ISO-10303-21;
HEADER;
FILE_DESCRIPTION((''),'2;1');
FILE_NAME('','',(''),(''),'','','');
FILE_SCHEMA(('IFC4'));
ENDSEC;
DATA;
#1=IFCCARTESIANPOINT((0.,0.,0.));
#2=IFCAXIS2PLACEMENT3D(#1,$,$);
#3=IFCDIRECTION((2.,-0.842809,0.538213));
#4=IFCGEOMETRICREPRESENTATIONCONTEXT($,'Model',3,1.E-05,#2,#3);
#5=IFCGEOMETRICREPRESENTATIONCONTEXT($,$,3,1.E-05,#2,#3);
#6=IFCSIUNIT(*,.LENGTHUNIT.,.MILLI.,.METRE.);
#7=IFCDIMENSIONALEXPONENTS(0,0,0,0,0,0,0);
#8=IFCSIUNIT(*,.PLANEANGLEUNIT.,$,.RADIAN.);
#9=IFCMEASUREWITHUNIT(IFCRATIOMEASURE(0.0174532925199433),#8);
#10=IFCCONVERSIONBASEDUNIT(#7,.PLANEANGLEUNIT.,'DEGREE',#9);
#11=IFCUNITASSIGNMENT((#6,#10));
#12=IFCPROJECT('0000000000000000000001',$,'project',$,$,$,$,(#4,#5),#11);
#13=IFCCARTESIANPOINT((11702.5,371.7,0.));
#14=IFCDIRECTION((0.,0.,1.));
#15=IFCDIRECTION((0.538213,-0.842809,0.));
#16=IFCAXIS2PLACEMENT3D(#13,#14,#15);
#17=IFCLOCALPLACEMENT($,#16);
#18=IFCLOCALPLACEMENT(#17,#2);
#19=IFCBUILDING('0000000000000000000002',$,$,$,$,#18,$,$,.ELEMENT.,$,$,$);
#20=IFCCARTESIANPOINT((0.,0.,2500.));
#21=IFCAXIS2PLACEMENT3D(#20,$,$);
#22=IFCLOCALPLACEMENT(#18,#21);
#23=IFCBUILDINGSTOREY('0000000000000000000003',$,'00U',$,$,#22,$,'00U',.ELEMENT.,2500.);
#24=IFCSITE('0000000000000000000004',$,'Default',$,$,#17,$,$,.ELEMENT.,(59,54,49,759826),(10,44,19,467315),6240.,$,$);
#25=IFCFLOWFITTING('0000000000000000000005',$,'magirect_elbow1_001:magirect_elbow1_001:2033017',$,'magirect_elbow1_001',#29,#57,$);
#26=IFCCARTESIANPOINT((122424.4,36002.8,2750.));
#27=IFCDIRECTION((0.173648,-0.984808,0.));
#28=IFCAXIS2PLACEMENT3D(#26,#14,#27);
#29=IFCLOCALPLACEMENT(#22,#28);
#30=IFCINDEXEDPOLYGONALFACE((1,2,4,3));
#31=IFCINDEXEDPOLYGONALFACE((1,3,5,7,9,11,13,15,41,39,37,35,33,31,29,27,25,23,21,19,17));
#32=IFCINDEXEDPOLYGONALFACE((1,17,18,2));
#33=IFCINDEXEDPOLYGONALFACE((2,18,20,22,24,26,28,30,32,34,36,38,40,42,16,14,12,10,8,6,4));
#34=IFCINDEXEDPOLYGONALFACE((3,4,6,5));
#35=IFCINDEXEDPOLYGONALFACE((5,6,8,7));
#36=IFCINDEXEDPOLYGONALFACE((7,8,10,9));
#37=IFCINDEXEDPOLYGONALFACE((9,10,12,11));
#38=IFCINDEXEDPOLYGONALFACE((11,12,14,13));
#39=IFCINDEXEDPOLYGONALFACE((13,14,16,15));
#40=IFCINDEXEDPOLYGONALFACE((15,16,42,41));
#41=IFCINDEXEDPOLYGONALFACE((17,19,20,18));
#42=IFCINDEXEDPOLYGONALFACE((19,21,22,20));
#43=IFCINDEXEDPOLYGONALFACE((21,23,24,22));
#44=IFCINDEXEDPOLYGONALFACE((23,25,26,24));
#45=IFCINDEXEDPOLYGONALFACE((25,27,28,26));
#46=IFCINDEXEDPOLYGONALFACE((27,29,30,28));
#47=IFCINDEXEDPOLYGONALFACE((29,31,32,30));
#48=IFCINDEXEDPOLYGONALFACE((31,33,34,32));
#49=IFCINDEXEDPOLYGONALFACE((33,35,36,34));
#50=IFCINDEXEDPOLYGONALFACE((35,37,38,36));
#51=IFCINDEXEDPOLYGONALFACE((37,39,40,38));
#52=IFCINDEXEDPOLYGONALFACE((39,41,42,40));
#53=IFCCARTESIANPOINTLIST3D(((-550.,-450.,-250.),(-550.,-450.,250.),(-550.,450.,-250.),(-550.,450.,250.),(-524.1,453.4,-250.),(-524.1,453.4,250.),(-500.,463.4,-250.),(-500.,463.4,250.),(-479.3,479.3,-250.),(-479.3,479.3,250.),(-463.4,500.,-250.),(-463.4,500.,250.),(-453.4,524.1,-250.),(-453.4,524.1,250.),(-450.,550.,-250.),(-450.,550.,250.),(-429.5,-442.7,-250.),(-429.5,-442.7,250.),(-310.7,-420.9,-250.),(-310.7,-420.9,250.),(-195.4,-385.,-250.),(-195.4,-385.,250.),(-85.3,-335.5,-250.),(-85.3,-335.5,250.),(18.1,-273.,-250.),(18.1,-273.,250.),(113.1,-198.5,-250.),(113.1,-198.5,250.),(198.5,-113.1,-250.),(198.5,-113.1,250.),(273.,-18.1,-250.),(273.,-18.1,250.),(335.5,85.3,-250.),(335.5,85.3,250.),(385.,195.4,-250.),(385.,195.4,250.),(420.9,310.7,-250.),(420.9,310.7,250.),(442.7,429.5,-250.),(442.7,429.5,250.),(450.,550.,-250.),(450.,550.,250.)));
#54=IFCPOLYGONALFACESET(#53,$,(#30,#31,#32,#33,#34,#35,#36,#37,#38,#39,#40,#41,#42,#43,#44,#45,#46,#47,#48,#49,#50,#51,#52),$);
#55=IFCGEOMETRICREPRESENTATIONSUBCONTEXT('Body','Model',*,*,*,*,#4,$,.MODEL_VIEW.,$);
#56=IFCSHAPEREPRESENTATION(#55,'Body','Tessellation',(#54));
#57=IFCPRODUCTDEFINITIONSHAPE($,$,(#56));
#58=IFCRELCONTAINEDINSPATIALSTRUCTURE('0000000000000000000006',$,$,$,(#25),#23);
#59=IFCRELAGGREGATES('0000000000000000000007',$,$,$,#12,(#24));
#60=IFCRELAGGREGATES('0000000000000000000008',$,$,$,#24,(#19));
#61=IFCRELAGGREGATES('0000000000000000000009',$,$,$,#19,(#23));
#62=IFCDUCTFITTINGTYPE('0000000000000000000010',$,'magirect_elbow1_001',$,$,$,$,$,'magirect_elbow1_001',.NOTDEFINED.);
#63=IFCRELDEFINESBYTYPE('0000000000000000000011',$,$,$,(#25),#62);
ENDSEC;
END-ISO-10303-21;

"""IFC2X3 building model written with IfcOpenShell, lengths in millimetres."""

from ifc_helpers import new_model, entity, si_unit, converted_unit, direction, frame, frame_2d, origin, place, context, subcontext, project, spatial, polyline, circle_curve, parameter, trimmed, segment, composite_curve, outline, extrude, source, transform, mapped, type_object, type_shapes, element, save


model = new_model("IFC2X3")

# Units and contexts
model_context = context("Model", 3, precision=1e-05, world=origin(), true_north=direction((2.0, -0.842809, 0.538213)))
context_of_model = context(None, 3, precision=1e-05, world=origin(), true_north=direction((2.0, -0.842809, 0.538213)))
body_context = subcontext(model_context, "Body", "Model", "MODEL_VIEW")
ifc_project = project(units=[si_unit("LENGTHUNIT", "METRE", prefix="MILLI"), converted_unit("PLANEANGLEUNIT", "DEGREE", entity("IfcRatioMeasure", 0.0174532925199433), si_unit("PLANEANGLEUNIT", "RADIAN"), dimensions=[0, 0, 0, 0, 0, 0, 0])], contexts=[model_context, context_of_model])

# Site, building, storey
site_placement = place(None, frame((11702.5, 371.7, 0.0), z_axis=(0.0, 0.0, 1.0), x_axis=(0.538213, -0.842809, 0.0)))
site = spatial("IfcSite", under=ifc_project, at=site_placement, Name="Default", CompositionType="ELEMENT", RefLatitude=(59, 54, 49, 759826), RefLongitude=(10, 44, 19, 467315), RefElevation=6240.0)
building_placement = place(site_placement, origin())
building = spatial("IfcBuilding", under=site, at=building_placement, CompositionType="ELEMENT")
storey_placement = place(building_placement, frame((0.0, 0.0, 2500.0)))
storey = spatial("IfcBuildingStorey", under=building, at=storey_placement, Name="00U", LongName="00U", CompositionType="ELEMENT", Elevation=2500.0)

# Flow fitting
duct_fitting_type_1 = type_object("IfcDuctFittingType", Name="magirect_elbow1_001", ElementType="magirect_elbow1_001", PredefinedType="NOTDEFINED")
shared_shape_1 = source(origin(), body_context, "Body", "SweptSolid", [
    extrude(outline(composite_curve([segment(polyline([(-725.0, -275.0), (175.0, -275.0)]), True, "CONTINUOUS"), segment(trimmed(circle_curve(frame_2d((275.0, -275.0), x_axis=(0.0, 1.0)), 100.0), [parameter(0.0)], [parameter(90.0)], True, "PARAMETER"), False, "CONTINUOUS"), segment(polyline([(275.0, -175.0), (275.0, 725.0)]), True, "CONTINUOUS"), segment(trimmed(circle_curve(frame_2d((275.0, -275.0), x_axis=(0.0, 1.0)), 1000.0), [parameter(0.0)], [parameter(90.0)], True, "PARAMETER"), True, "CONTINUOUS")], self_intersect=False)), frame((-275.0, 275.0, -250.0), z_axis=(0.0, 0.0, 1.0), x_axis=(-1.0, 0.0, 0.0)), (0.0, 0.0, 1.0), 500.0),
])
type_shapes(duct_fitting_type_1, [shared_shape_1])
flow_fitting_1_placement = place(storey_placement, frame((122424.4, 36002.8, 2750.0), z_axis=(0.0, 0.0, 1.0), x_axis=(0.173648, -0.984808, 0.0)))
element("IfcFlowFitting", 1, at=flow_fitting_1_placement, inside=storey, type_object=duct_fitting_type_1, Name="magirect_elbow1_001:magirect_elbow1_001:2033017", ObjectType="magirect_elbow1_001", context=body_context, shape_type="MappedRepresentation", body=[
    mapped(shared_shape_1, transform((0.0, 0.0, 0.0), scale=1.0)),
])

save(model, "model.ifc")
